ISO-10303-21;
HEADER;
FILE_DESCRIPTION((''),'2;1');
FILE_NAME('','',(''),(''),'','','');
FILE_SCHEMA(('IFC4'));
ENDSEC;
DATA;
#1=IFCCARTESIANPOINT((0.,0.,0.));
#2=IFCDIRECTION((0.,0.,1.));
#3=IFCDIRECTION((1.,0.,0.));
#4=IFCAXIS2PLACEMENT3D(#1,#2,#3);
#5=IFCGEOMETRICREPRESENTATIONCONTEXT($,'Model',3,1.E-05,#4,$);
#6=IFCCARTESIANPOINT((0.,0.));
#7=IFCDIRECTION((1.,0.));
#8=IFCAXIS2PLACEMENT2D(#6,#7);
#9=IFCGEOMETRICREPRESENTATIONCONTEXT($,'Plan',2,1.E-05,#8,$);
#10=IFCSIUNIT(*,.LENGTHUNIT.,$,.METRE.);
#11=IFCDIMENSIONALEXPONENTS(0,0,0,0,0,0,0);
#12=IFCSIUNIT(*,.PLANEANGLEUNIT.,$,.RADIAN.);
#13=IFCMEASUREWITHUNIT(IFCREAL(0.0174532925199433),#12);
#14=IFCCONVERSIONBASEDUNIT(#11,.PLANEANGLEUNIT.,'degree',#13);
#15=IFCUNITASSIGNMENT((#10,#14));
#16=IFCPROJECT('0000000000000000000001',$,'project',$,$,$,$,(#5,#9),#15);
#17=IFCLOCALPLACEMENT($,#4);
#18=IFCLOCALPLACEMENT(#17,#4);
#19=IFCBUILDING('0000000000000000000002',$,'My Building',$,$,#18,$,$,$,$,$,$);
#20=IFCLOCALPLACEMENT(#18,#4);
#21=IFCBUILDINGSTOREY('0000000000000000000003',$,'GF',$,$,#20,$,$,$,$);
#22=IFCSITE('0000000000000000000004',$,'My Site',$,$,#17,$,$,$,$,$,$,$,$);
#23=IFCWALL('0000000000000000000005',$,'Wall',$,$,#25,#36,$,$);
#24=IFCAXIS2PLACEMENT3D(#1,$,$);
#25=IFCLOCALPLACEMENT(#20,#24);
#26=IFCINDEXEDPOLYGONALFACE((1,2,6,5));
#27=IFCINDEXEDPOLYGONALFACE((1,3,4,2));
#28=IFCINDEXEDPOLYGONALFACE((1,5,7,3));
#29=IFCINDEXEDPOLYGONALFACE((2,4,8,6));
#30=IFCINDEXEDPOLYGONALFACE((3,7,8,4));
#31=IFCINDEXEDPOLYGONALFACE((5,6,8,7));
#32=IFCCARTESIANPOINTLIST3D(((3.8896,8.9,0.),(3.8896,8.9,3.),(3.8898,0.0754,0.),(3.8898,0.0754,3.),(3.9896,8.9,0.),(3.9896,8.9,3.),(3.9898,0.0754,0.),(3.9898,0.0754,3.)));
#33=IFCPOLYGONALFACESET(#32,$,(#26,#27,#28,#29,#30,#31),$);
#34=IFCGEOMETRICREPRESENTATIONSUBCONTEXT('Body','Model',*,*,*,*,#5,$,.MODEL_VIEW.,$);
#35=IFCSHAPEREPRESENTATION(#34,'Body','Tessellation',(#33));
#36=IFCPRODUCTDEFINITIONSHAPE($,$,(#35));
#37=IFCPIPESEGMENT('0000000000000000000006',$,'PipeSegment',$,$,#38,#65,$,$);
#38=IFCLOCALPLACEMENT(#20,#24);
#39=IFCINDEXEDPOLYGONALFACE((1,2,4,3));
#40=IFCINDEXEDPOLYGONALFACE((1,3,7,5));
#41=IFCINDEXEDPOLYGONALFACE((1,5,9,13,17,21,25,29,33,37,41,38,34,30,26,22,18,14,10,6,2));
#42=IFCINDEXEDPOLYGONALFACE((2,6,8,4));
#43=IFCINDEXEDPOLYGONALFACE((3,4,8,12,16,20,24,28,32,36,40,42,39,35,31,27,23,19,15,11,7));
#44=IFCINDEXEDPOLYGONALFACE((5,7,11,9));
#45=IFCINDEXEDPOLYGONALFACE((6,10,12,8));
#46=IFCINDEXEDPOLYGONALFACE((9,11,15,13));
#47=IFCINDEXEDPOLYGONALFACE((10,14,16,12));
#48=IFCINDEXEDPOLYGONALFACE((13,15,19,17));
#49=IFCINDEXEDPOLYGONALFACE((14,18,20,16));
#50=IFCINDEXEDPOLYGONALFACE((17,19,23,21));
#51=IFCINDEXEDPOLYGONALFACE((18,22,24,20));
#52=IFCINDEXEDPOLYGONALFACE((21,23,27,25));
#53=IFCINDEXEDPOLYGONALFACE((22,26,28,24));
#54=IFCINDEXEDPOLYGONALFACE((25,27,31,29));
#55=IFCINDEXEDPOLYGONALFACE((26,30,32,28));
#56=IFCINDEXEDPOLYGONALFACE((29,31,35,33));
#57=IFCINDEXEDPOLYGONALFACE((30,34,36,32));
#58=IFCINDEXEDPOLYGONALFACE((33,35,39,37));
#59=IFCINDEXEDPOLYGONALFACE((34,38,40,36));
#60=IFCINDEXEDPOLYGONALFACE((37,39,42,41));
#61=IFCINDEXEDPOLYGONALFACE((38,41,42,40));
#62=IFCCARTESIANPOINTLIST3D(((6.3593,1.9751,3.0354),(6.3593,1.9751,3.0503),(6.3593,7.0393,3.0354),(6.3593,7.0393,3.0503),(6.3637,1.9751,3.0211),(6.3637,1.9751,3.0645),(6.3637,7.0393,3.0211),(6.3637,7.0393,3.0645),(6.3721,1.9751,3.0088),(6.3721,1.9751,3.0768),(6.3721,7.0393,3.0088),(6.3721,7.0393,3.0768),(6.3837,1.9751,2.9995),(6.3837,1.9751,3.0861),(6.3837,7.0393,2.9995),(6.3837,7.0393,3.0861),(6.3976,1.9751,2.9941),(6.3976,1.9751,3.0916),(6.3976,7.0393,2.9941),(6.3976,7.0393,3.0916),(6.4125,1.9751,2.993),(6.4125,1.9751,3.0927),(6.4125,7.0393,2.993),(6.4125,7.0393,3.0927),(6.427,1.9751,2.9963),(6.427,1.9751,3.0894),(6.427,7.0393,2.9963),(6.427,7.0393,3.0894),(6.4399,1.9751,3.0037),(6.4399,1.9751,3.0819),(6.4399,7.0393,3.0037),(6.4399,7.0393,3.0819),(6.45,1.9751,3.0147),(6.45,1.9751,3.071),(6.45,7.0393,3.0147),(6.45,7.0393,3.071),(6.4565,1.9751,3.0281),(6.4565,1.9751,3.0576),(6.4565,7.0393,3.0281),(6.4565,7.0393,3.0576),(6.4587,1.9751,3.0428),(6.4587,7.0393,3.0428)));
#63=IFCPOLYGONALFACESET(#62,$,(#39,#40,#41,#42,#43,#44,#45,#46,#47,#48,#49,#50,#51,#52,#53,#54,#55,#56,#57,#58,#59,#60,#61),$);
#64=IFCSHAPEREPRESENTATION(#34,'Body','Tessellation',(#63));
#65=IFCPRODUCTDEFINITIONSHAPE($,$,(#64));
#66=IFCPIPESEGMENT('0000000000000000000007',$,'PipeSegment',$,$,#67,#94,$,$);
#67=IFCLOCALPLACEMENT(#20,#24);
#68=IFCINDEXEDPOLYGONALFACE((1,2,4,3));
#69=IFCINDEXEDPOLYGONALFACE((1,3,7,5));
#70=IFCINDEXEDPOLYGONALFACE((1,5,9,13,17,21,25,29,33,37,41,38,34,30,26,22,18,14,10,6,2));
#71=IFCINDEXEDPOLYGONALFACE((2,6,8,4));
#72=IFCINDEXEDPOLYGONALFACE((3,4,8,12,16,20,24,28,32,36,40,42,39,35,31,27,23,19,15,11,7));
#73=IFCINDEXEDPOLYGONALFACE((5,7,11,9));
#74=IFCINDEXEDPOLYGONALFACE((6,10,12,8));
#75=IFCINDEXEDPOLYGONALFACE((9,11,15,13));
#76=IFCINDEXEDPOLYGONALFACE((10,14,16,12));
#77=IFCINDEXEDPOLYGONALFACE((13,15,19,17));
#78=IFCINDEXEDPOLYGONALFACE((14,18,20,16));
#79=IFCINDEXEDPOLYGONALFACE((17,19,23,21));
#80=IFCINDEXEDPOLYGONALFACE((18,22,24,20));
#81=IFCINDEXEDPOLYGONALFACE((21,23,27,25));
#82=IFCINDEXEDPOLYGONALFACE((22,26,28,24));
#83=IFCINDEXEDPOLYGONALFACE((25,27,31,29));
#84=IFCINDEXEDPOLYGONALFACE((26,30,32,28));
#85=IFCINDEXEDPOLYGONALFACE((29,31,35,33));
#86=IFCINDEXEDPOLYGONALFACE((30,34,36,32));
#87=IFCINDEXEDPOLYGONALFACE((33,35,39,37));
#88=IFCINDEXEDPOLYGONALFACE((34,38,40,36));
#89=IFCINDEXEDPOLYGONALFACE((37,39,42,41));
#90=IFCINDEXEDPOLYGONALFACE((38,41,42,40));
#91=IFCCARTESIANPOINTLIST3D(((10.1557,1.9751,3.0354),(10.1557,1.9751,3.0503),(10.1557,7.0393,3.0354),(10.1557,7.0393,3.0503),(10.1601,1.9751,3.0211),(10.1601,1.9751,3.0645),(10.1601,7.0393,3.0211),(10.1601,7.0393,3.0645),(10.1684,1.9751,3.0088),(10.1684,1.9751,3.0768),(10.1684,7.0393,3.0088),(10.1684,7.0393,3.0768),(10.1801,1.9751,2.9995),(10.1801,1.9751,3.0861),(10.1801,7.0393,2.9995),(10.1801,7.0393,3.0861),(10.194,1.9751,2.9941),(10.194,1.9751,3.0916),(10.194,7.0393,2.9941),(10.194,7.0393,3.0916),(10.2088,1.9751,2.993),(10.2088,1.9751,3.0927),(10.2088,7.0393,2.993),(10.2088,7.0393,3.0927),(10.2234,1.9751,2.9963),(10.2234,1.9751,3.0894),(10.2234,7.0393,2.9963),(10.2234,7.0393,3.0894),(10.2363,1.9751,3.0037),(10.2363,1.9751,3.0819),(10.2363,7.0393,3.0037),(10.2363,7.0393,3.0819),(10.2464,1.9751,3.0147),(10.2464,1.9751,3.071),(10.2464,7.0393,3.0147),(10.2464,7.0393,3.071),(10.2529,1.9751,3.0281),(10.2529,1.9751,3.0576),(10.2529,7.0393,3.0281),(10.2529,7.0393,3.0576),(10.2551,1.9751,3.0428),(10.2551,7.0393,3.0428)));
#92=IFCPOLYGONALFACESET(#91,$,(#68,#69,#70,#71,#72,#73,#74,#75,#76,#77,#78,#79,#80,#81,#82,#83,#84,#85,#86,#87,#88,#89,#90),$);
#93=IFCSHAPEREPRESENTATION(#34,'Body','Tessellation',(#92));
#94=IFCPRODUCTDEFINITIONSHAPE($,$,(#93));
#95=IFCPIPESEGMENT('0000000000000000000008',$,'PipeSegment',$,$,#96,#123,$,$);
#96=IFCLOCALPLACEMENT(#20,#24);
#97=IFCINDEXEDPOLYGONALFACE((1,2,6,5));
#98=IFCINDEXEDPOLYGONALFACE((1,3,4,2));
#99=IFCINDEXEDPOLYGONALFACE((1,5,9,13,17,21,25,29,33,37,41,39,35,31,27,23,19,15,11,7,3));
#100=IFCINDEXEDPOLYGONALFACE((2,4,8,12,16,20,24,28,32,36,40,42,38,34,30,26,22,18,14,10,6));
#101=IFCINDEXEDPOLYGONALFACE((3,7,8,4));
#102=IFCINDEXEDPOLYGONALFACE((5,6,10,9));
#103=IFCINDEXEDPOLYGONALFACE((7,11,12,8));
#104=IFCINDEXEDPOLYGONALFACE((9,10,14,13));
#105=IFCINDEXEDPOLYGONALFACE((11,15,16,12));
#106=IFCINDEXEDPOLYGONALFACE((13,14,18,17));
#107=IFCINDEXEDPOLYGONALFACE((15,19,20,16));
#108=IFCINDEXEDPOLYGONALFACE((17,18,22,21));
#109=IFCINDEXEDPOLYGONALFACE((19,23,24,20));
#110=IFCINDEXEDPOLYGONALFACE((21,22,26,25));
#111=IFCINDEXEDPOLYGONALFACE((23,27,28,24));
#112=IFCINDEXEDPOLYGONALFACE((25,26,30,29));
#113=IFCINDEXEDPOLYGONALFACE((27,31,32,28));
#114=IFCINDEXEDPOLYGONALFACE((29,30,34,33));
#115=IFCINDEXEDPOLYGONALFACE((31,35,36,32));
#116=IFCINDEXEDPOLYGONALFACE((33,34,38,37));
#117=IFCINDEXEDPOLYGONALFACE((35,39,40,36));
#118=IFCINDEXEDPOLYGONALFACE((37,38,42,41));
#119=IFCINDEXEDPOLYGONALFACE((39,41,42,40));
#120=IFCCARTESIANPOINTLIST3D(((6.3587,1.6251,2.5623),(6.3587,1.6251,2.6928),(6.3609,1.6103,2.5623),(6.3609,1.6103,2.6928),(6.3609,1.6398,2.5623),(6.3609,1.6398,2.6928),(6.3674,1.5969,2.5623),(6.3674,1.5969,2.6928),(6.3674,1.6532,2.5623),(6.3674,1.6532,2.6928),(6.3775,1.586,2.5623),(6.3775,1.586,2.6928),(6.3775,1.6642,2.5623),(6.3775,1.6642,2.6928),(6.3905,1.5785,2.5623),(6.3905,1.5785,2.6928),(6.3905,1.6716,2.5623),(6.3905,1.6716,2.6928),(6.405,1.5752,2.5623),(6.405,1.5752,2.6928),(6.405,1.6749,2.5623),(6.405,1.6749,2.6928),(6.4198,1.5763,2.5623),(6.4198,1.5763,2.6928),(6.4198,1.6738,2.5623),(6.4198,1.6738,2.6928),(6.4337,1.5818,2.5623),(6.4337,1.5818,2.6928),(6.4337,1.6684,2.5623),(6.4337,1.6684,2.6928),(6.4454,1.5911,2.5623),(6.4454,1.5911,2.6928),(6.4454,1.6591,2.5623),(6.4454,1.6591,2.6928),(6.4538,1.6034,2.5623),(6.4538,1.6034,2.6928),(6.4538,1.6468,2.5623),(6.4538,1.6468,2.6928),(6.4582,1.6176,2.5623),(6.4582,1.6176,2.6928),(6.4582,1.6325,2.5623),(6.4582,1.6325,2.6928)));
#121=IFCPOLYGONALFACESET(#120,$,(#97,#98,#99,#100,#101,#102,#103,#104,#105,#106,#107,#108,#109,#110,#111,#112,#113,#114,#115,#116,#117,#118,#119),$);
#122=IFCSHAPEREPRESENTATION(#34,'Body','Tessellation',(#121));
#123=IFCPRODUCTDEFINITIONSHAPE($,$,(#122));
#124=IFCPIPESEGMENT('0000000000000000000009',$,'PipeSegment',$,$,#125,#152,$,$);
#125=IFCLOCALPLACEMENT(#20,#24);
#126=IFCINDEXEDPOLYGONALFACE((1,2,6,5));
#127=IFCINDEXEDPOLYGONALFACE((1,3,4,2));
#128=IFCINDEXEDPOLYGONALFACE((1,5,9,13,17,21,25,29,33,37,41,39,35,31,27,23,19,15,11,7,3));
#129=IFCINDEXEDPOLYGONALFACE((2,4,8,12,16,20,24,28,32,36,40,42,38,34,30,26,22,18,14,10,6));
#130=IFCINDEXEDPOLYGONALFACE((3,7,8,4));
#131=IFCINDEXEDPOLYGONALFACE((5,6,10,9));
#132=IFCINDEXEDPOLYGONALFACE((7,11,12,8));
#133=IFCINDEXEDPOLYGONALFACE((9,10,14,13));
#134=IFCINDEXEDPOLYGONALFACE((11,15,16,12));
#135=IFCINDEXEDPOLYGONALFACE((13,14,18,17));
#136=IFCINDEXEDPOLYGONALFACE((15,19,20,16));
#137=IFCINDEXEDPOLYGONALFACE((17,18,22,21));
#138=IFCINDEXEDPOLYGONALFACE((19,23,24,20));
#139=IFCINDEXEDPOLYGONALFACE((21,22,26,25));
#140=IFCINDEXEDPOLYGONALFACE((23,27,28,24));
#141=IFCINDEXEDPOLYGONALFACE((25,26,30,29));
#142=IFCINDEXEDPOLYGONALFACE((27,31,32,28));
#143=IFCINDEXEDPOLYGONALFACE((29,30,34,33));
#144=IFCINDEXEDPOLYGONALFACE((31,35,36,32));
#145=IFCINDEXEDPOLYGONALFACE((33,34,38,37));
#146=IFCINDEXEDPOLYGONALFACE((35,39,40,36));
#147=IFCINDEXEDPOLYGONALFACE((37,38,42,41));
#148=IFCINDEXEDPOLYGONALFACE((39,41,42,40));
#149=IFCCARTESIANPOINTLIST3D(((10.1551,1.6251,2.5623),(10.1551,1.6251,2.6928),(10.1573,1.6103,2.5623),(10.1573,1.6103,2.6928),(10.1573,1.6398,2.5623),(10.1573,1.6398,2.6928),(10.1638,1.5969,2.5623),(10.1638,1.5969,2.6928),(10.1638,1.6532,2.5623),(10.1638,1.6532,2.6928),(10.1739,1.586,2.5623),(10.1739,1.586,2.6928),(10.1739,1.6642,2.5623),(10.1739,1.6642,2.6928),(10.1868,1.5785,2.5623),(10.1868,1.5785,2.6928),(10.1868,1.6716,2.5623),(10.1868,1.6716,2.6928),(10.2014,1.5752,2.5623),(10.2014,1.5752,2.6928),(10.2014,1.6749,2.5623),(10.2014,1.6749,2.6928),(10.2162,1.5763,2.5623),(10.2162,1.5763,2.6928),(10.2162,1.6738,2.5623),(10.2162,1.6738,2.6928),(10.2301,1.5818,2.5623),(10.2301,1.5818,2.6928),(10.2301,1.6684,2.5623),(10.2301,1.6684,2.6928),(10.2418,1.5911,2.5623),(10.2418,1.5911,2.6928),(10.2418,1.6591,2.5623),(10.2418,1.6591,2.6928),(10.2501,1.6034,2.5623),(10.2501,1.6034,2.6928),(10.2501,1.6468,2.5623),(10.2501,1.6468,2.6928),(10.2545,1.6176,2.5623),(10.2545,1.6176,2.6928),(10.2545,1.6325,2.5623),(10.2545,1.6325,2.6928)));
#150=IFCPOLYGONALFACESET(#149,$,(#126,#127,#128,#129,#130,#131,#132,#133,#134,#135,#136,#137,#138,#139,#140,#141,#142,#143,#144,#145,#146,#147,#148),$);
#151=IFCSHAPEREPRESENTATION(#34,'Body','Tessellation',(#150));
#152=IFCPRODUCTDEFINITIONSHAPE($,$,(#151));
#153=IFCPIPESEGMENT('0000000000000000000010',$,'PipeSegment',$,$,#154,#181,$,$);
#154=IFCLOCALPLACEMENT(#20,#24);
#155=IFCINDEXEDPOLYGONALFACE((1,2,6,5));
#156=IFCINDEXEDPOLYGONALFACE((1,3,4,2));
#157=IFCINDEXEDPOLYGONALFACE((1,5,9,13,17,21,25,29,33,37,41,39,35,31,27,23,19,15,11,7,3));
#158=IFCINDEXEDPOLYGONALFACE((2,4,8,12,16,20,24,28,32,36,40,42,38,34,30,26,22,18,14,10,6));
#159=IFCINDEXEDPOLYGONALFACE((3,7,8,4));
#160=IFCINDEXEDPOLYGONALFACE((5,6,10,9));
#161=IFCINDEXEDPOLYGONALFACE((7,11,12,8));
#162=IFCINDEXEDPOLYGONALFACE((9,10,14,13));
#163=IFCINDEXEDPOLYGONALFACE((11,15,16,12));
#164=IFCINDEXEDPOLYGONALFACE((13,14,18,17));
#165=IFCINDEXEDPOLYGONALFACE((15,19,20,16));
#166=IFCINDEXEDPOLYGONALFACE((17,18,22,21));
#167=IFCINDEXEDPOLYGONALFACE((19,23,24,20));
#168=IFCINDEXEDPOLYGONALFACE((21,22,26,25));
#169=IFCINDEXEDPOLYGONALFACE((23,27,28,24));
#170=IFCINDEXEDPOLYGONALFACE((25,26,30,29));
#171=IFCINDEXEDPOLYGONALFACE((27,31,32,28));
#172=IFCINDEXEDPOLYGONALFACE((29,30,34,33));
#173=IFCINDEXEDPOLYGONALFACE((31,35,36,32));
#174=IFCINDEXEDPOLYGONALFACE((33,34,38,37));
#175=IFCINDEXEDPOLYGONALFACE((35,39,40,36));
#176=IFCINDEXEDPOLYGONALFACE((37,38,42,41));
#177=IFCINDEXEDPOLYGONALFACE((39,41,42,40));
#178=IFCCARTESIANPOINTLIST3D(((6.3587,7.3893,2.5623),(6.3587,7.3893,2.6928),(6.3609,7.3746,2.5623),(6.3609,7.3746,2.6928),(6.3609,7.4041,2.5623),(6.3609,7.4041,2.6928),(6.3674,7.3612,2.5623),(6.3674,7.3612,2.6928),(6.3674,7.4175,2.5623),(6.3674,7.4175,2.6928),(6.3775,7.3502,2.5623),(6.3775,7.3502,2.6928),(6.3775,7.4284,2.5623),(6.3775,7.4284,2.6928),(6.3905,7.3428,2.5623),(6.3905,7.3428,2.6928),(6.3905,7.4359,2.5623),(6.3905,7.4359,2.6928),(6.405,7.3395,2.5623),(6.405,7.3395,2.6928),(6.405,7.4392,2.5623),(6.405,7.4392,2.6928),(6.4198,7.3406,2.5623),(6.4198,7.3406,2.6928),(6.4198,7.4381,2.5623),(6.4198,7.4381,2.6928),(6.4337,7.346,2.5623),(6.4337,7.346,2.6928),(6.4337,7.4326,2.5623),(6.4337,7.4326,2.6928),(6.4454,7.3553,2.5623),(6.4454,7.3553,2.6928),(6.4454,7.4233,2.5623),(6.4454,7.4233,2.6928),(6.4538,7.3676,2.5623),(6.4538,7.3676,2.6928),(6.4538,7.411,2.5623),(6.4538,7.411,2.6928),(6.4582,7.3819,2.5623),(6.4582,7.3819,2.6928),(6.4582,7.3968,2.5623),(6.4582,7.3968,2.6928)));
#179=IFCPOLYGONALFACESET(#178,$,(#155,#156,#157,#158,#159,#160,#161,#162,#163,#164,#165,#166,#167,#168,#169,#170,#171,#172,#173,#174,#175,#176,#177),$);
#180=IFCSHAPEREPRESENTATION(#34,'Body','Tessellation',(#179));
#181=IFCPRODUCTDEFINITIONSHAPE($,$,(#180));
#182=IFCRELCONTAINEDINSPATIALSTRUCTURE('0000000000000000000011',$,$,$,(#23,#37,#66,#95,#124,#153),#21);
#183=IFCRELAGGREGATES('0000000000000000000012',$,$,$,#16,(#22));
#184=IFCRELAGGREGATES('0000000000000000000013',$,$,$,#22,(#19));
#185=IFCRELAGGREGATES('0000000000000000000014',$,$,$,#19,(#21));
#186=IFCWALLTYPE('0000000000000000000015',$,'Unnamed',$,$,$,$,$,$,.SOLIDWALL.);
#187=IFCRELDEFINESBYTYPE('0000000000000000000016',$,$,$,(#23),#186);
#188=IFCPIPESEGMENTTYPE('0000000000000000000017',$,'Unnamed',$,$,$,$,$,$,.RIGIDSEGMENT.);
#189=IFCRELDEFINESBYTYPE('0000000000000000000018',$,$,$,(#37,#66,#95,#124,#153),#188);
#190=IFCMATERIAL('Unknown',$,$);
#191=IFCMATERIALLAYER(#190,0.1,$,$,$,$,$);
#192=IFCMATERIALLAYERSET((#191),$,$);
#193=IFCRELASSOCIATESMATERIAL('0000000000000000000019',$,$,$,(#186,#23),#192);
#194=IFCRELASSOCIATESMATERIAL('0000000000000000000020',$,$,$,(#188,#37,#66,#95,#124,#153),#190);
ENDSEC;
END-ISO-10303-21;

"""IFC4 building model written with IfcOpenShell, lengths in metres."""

from ifc_helpers import new_model, entity, si_unit, converted_unit, frame, origin_with_axes, origin_2d_with_axis, place, context, subcontext, project, spatial, line, indexed_curve, circle, outline, extrude, material, layer, layer_set, layer_usage, material_profile, profile_set, profile_usage, type_object, element, save


model = new_model("IFC4")

# Units and contexts
model_context = context("Model", 3, precision=1e-05, world=origin_with_axes())
plan_context = context("Plan", 2, precision=1e-05, world=origin_2d_with_axis())
body_context_1 = subcontext(model_context, "Body", "Model", "MODEL_VIEW")
ifc_project = project(units=[si_unit("LENGTHUNIT", "METRE"), converted_unit("PLANEANGLEUNIT", "degree", entity("IfcReal", 0.0174532925199433), si_unit("PLANEANGLEUNIT", "RADIAN"), dimensions=[0, 0, 0, 0, 0, 0, 0])], contexts=[model_context, plan_context])

# Site, building, storey
site_placement = place(None, origin_with_axes())
site = spatial("IfcSite", under=ifc_project, at=site_placement, Name="My Site")
building_placement = place(site_placement, origin_with_axes())
building = spatial("IfcBuilding", under=site, at=building_placement, Name="My Building")
storey_placement = place(building_placement, origin_with_axes())
storey = spatial("IfcBuildingStorey", under=building, at=storey_placement, Name="GF")

# Wall
ifc_material = material(Name="Unknown")
ifc_layer = layer(ifc_material, 0.1)
ifc_layer_set = layer_set([ifc_layer])
ifc_layer_usage_1 = layer_usage(ifc_layer_set, "AXIS2", "POSITIVE", 0.0)
wall_type = type_object("IfcWallType", Name="Unnamed", PredefinedType="SOLIDWALL", material=ifc_layer_set)
wall_1_placement = place(storey_placement, frame((3.9898, 0.0754, 0.0), z_axis=(0.0, 0.0, 1.0), x_axis=(-0.000021, 1.0, 0.0)))
element("IfcWall", 1, at=wall_1_placement, inside=storey, type_object=wall_type, material=ifc_layer_usage_1, Name="Wall", context=body_context_1, shape_type="SweptSolid", body=[
    extrude(outline(indexed_curve([(0.0, 0.0), (0.0, 0.1), (8.8246, 0.1), (8.8246, 0.0)], segments=[line(1, 2, 3, 4, 1)])), origin_with_axes(), (0.0, 0.0, 1.0), 3.0),
])

# Pipe segments
ifc_material_profile = material_profile(ifc_material, circle(Radius=0.05))
ifc_profile_set = profile_set([ifc_material_profile])
ifc_profile_usage_1 = profile_usage(ifc_profile_set, cardinal=5)
pipe_segment_type = type_object("IfcPipeSegmentType", Name="Unnamed", PredefinedType="RIGIDSEGMENT", material=ifc_profile_set)
pipe_segment_1_placement = place(storey_placement, frame((6.4087, 7.0393, 3.0428), z_axis=(0.0, -1.0, 0.0), x_axis=(1.0, 0.0, 0.0)))
element("IfcPipeSegment", 2, at=pipe_segment_1_placement, inside=storey, type_object=pipe_segment_type, material=ifc_profile_usage_1, Name="PipeSegment", context=body_context_1, shape_type="SweptSolid", body=[
    extrude(circle(Radius=0.05), origin_with_axes(), (0.0, 0.0, 1.0), 5.0643),
])
ifc_profile_usage_2 = profile_usage(ifc_profile_set, cardinal=5)
pipe_segment_2_placement = place(storey_placement, frame((10.2051, 7.0393, 3.0428), z_axis=(0.0, -1.0, 0.0), x_axis=(1.0, 0.0, 0.0)))
element("IfcPipeSegment", 3, at=pipe_segment_2_placement, inside=storey, type_object=pipe_segment_type, material=ifc_profile_usage_2, Name="PipeSegment", context=body_context_1, shape_type="SweptSolid", body=[
    extrude(circle(Radius=0.05), origin_with_axes(), (0.0, 0.0, 1.0), 5.0643),
])
ifc_profile_usage_3 = profile_usage(ifc_profile_set, cardinal=5)
pipe_segment_3_placement = place(storey_placement, frame((6.4087, 1.6251, 2.6928), z_axis=(0.0, 0.0, -1.0), x_axis=(-1.0, 0.0, 0.0)))
element("IfcPipeSegment", 4, at=pipe_segment_3_placement, inside=storey, type_object=pipe_segment_type, material=ifc_profile_usage_3, Name="PipeSegment", context=body_context_1, shape_type="SweptSolid", body=[
    extrude(circle(Radius=0.05), origin_with_axes(), (0.0, 0.0, 1.0), 0.1306),
])
ifc_profile_usage_4 = profile_usage(ifc_profile_set, cardinal=5)
pipe_segment_4_placement = place(storey_placement, frame((10.2051, 1.6251, 2.6928), z_axis=(0.0, 0.0, -1.0), x_axis=(-1.0, 0.0, 0.0)))
element("IfcPipeSegment", 5, at=pipe_segment_4_placement, inside=storey, type_object=pipe_segment_type, material=ifc_profile_usage_4, Name="PipeSegment", context=body_context_1, shape_type="SweptSolid", body=[
    extrude(circle(Radius=0.05), origin_with_axes(), (0.0, 0.0, 1.0), 0.1306),
])
ifc_profile_usage_5 = profile_usage(ifc_profile_set, cardinal=5)
pipe_segment_5_placement = place(storey_placement, frame((6.4087, 7.3893, 2.6928), z_axis=(0.0, 0.0, -1.0), x_axis=(-1.0, 0.0, 0.0)))
element("IfcPipeSegment", 6, at=pipe_segment_5_placement, inside=storey, type_object=pipe_segment_type, material=ifc_profile_usage_5, Name="PipeSegment", context=body_context_1, shape_type="SweptSolid", body=[
    extrude(circle(Radius=0.05), origin_with_axes(), (0.0, 0.0, 1.0), 0.1306),
])

save(model, "model.ifc")
